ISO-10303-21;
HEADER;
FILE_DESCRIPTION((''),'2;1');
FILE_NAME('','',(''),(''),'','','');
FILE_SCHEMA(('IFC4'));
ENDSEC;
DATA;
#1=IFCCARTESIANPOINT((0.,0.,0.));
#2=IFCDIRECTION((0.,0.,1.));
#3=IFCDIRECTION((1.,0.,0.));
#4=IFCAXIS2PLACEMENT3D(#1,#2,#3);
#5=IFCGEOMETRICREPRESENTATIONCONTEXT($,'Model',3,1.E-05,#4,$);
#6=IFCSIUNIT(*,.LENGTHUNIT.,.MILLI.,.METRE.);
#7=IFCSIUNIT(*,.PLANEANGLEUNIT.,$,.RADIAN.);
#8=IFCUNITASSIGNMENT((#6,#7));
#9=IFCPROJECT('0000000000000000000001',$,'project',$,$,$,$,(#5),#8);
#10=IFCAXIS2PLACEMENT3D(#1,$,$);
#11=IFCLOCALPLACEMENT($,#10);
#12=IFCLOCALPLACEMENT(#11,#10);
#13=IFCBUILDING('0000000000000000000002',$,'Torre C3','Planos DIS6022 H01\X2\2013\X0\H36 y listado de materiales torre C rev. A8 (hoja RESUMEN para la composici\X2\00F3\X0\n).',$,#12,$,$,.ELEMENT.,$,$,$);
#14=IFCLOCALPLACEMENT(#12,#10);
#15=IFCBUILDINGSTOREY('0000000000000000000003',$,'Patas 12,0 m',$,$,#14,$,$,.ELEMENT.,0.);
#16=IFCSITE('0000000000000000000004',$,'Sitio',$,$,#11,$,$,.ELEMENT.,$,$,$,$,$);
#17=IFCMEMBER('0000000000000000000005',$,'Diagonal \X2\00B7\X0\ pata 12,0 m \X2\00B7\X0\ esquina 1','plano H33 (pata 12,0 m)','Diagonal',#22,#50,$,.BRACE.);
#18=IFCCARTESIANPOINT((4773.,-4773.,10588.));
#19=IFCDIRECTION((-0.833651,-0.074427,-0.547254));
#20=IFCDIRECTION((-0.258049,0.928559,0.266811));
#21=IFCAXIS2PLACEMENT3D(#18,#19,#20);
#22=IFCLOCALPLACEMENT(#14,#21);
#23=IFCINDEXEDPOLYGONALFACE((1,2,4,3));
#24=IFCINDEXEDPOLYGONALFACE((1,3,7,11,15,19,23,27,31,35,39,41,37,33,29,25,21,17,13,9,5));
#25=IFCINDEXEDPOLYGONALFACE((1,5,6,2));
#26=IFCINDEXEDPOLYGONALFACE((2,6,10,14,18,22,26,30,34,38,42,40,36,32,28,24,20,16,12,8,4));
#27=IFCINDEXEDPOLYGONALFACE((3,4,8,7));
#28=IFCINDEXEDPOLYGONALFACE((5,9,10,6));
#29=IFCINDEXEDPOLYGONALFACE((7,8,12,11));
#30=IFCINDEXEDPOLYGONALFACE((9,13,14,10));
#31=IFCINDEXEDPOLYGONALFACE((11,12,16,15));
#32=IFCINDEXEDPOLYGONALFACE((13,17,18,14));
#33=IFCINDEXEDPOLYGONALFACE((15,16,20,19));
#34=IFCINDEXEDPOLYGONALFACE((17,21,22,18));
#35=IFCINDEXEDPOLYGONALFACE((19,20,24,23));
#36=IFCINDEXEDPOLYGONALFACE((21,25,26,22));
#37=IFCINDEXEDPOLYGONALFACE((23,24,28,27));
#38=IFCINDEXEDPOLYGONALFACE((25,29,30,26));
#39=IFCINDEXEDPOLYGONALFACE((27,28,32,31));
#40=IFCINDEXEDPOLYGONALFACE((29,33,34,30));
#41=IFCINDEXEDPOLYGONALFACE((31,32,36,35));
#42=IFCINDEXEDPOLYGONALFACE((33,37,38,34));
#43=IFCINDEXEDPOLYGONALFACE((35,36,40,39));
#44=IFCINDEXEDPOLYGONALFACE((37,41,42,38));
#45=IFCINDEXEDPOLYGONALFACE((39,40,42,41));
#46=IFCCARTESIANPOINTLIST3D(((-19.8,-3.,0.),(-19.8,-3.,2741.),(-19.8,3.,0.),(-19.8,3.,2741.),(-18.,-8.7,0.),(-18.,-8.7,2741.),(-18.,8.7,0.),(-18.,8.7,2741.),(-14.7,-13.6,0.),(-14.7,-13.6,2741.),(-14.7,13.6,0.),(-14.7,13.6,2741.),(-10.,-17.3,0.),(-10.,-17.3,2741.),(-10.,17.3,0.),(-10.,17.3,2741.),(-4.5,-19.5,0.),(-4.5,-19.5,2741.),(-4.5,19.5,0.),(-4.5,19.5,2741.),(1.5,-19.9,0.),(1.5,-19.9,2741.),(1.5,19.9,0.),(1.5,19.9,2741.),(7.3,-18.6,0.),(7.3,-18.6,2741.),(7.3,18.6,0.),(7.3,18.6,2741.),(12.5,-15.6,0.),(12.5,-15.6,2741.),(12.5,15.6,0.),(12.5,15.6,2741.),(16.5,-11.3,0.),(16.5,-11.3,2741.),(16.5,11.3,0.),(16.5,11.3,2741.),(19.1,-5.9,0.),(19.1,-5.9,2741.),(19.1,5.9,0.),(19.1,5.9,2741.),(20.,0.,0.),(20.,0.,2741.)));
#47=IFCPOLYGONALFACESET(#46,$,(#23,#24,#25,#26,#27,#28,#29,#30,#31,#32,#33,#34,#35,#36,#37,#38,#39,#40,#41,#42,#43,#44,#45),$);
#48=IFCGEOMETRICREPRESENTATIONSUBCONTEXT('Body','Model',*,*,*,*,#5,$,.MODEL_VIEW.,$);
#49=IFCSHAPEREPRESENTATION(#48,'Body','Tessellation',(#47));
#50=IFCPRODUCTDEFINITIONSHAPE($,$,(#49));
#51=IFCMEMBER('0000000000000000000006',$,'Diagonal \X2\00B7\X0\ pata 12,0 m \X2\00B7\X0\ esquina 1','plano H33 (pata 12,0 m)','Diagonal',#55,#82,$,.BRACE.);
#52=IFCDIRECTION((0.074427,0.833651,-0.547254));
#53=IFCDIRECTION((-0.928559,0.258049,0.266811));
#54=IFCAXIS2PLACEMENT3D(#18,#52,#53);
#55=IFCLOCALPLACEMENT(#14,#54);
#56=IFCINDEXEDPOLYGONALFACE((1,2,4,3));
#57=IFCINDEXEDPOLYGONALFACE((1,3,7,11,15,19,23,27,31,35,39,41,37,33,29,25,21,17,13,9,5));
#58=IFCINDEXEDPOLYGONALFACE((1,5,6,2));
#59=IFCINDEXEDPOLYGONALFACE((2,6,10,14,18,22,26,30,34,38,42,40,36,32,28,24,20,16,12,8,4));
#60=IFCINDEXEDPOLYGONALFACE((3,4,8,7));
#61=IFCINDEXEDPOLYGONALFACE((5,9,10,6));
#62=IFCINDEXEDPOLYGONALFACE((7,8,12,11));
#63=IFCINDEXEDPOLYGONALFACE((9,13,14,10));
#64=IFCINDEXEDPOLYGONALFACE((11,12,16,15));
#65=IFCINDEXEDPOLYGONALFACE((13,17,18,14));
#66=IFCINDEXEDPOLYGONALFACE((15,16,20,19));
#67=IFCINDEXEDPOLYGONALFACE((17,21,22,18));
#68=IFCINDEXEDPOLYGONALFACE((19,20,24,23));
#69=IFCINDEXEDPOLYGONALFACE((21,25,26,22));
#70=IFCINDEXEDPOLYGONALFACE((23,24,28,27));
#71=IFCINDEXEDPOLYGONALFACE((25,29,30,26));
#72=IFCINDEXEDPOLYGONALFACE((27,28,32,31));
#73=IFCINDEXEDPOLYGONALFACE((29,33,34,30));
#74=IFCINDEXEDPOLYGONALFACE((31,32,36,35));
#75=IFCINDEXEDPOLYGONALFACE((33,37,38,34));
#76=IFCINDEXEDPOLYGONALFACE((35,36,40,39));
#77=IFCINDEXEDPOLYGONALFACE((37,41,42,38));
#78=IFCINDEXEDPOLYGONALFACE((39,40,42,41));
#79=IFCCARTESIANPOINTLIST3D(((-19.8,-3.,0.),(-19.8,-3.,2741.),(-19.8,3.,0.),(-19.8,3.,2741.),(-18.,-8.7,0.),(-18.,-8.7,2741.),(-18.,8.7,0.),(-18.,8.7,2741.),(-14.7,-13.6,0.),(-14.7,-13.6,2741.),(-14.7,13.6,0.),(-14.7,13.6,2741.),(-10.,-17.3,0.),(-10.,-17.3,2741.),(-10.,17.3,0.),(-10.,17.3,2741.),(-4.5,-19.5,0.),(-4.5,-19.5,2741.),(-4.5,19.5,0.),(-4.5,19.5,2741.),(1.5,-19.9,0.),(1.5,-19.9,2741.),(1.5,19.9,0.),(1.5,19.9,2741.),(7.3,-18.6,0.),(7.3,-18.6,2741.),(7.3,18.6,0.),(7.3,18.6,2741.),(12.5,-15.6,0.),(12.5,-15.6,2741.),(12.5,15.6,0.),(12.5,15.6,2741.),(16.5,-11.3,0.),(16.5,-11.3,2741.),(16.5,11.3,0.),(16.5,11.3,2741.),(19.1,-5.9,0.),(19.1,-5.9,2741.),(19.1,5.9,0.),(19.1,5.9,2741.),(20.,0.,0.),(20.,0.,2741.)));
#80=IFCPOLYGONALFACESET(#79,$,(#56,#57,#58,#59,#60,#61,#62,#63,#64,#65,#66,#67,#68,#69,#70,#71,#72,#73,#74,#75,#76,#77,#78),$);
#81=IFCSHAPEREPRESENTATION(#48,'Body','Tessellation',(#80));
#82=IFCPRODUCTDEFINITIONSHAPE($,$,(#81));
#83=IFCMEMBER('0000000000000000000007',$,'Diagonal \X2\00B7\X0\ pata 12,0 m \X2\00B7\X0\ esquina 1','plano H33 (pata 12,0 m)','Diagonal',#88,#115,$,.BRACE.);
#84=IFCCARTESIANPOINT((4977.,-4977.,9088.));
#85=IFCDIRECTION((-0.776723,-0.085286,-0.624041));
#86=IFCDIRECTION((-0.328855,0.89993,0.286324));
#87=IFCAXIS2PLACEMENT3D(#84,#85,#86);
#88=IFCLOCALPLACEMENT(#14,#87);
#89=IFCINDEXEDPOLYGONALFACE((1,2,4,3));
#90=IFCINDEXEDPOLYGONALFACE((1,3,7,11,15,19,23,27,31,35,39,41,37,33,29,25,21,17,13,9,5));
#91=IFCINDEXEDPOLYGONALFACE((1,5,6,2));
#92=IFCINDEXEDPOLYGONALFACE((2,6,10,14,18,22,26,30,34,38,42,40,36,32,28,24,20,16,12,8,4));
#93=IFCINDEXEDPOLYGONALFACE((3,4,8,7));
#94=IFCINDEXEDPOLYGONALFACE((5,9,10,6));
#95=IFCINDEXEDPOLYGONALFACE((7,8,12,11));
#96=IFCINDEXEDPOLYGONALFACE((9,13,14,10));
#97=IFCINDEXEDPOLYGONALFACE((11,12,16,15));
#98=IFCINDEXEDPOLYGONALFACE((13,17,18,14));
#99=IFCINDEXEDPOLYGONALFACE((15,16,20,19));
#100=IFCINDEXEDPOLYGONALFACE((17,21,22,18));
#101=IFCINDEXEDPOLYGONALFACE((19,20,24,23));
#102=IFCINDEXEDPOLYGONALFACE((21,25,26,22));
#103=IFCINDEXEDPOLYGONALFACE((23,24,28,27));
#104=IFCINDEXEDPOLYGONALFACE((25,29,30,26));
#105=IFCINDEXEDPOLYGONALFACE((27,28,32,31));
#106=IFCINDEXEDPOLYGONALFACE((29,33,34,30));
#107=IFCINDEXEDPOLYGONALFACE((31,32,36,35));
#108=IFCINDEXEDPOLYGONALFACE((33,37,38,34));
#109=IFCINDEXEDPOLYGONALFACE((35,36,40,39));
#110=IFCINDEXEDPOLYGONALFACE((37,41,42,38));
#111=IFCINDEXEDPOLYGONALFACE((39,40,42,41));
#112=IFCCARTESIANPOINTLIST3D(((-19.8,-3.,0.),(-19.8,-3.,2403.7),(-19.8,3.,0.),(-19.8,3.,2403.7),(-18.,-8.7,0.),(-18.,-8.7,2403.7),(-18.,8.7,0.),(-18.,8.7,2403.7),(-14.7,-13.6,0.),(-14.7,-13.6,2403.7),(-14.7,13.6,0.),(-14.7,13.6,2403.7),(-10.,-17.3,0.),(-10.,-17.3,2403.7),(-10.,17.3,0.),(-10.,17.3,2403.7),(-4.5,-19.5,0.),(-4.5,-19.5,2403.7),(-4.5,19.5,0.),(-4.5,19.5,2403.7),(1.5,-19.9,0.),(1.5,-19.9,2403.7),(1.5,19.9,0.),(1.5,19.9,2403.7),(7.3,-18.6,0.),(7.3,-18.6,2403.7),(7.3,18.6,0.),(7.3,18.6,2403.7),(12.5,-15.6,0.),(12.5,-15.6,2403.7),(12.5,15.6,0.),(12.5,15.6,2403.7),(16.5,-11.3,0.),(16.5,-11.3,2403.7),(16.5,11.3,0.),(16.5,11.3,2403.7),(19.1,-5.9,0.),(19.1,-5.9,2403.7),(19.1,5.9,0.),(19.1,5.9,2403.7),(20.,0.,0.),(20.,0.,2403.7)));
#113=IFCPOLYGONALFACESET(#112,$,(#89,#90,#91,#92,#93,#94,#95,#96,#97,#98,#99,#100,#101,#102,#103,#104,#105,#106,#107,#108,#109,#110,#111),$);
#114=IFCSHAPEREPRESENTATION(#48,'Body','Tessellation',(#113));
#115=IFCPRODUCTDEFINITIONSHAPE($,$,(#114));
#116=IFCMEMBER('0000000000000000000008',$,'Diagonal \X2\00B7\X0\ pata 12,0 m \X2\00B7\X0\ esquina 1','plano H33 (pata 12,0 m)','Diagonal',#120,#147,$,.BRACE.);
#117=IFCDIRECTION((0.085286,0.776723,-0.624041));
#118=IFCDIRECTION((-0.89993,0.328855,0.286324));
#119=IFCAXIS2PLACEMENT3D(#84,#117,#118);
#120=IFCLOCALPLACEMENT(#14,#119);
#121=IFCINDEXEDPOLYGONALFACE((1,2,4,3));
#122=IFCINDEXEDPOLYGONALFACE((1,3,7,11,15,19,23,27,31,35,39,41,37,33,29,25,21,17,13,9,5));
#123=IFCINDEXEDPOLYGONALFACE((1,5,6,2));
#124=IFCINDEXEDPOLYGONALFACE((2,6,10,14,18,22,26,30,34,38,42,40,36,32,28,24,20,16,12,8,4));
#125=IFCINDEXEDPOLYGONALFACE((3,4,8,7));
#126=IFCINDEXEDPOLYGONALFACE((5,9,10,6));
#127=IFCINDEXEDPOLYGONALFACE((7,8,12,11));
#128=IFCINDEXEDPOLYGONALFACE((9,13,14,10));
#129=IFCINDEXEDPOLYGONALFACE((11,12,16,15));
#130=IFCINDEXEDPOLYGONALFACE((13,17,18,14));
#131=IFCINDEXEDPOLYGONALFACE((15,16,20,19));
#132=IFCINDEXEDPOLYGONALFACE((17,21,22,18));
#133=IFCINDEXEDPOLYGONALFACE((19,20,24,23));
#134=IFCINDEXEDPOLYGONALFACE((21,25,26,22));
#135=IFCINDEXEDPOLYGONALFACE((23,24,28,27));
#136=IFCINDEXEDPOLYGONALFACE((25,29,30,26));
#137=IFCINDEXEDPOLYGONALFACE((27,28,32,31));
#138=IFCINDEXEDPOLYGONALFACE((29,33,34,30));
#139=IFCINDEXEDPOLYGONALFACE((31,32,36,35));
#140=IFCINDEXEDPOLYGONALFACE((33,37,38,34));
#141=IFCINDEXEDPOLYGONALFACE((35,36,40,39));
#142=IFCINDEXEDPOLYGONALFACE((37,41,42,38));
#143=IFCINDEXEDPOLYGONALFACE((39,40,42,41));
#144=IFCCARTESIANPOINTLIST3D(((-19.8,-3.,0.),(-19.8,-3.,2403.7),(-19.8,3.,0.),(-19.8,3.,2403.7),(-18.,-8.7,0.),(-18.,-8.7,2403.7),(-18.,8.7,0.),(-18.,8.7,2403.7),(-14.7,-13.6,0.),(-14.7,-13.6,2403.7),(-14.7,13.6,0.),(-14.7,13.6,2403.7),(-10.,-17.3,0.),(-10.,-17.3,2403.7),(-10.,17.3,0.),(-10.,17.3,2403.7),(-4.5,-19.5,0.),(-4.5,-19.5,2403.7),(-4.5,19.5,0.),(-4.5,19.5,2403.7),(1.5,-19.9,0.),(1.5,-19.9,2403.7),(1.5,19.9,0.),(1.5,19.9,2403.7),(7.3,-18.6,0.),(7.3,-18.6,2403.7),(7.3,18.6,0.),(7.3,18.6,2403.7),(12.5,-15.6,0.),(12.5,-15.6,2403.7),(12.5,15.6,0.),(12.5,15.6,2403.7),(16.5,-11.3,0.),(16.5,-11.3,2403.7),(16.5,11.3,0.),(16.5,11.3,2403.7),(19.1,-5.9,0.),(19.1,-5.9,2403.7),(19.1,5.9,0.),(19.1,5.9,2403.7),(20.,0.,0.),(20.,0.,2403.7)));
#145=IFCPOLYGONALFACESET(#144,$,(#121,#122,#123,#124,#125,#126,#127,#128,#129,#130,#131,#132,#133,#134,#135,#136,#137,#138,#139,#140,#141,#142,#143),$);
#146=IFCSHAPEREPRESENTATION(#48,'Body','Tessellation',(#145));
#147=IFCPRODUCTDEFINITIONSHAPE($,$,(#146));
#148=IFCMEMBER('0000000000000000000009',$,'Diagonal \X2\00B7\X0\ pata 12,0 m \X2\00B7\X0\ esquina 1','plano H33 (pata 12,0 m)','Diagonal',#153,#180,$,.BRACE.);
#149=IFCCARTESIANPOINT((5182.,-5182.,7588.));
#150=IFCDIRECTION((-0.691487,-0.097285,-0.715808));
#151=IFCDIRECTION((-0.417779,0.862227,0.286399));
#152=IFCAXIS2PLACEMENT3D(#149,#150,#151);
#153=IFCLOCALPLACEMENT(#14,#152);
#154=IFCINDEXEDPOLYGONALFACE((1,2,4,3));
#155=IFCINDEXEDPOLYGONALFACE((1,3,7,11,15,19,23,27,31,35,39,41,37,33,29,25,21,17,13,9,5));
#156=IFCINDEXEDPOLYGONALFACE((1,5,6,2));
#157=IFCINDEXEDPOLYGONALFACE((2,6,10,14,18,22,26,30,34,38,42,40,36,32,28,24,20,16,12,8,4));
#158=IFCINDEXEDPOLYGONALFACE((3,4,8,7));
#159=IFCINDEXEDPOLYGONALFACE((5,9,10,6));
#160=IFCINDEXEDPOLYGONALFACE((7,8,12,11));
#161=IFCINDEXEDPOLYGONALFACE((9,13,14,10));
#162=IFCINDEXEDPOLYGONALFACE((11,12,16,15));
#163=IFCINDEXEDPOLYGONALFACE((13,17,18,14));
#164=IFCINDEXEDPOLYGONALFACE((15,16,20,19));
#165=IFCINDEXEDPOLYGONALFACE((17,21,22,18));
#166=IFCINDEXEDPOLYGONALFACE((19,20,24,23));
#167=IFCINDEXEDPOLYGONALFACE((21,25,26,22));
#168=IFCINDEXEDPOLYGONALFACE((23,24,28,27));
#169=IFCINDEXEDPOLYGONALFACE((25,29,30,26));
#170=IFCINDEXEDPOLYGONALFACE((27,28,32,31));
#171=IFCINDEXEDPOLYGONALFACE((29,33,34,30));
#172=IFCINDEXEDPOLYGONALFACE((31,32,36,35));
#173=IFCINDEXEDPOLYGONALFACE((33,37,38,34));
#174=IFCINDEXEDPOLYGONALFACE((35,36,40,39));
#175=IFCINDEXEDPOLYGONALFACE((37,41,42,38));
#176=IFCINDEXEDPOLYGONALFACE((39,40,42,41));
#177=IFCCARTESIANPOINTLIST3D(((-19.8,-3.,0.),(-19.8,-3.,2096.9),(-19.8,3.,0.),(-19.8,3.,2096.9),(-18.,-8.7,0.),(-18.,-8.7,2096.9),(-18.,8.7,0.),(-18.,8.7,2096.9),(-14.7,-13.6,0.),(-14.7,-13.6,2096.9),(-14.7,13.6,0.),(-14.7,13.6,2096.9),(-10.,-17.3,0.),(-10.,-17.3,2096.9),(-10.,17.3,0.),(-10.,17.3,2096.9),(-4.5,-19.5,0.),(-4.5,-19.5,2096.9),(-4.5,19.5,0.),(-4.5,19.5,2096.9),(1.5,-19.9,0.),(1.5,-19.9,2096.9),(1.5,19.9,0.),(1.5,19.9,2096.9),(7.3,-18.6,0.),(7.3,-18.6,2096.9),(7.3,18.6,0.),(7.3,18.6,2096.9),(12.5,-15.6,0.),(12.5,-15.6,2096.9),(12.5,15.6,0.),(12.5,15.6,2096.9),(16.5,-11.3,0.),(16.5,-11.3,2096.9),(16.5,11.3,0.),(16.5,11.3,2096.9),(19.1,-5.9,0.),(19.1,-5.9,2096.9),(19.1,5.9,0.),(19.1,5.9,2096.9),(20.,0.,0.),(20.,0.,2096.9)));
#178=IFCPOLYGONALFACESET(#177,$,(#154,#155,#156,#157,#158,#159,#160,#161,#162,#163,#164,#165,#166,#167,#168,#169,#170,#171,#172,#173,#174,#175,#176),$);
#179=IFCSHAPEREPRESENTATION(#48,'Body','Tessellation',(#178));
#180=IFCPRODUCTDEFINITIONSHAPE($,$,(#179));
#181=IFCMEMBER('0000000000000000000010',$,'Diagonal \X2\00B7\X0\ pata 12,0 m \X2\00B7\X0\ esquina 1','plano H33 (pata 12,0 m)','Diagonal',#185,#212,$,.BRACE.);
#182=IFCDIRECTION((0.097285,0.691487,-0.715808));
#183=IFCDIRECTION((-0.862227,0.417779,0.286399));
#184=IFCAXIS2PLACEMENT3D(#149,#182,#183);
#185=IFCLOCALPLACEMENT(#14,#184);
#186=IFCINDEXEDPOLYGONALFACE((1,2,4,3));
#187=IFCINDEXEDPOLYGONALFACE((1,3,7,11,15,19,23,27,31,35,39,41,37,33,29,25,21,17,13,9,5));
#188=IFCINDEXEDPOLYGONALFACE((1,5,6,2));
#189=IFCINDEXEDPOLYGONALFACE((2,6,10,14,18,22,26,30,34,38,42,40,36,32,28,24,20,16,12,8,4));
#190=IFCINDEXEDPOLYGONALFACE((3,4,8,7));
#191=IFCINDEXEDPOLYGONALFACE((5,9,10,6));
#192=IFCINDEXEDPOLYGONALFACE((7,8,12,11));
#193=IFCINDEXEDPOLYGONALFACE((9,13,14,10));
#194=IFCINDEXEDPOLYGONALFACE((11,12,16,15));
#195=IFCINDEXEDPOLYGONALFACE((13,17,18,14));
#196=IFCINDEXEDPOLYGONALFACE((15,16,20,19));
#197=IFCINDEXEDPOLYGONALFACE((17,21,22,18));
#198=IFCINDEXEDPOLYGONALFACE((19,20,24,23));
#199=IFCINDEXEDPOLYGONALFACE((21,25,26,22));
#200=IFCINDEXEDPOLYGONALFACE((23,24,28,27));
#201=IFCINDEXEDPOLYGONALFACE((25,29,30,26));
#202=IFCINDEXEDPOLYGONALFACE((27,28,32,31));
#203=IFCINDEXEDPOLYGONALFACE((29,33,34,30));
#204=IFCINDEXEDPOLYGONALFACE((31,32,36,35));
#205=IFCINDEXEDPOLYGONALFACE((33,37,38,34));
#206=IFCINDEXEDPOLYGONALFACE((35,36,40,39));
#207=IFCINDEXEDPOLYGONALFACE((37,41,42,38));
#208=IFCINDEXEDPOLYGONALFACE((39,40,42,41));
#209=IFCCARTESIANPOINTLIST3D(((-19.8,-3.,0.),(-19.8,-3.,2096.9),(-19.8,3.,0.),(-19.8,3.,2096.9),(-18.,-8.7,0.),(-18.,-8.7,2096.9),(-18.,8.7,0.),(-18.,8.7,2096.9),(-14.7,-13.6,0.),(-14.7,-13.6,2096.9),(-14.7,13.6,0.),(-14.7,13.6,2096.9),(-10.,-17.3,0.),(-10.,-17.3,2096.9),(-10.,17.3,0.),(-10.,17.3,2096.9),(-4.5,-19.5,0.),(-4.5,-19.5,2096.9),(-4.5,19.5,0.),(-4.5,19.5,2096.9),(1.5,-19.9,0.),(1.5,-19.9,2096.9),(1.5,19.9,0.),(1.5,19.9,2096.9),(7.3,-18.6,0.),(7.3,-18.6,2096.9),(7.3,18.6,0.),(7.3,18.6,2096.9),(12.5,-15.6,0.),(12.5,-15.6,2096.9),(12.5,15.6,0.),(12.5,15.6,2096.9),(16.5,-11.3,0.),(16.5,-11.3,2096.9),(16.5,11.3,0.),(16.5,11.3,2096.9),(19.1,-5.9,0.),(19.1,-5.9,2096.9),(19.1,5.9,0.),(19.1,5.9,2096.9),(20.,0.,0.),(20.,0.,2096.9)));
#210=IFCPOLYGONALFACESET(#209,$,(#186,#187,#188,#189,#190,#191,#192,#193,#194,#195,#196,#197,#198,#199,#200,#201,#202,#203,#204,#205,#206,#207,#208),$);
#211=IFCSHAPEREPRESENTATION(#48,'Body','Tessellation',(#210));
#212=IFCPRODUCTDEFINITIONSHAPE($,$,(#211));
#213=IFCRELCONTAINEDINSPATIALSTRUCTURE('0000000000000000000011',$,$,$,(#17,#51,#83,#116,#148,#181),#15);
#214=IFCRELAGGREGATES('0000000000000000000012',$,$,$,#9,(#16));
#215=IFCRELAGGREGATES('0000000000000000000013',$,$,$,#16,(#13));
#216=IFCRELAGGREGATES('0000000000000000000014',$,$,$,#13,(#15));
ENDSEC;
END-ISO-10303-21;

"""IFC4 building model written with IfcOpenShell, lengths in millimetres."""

from ifc_helpers import new_model, si_unit, frame, origin, origin_with_axes, place, context, subcontext, project, spatial, circle, extrude, element, save


model = new_model("IFC4")

# Units and contexts
model_context = context("Model", 3, precision=1e-05, world=origin_with_axes())
body_context = subcontext(model_context, "Body", "Model", "MODEL_VIEW")
ifc_project = project(units=[si_unit("LENGTHUNIT", "METRE", prefix="MILLI"), si_unit("PLANEANGLEUNIT", "RADIAN")], contexts=[model_context])

# Site, building, storey
site_placement = place(None, origin())
site = spatial("IfcSite", under=ifc_project, at=site_placement, Name="Sitio", CompositionType="ELEMENT")
building_placement = place(site_placement, origin())
building = spatial("IfcBuilding", under=site, at=building_placement, Name="Torre C3", Description="Planos DIS6022 H01–H36 y listado de materiales torre C rev. A8 (hoja RESUMEN para la composición).", CompositionType="ELEMENT")
storey_placement = place(building_placement, origin())
storey = spatial("IfcBuildingStorey", under=building, at=storey_placement, Name="Patas 12,0 m", CompositionType="ELEMENT", Elevation=0.0)

# Members
for number, where, z_axis, x_axis, name in (
    (1, (4773.0, -4773.0, 10588.0), (-0.833651, -0.074427, -0.547254), (-0.258049, 0.928559, 0.266811), "Diagonal · pata 12,0 m · esquina 1"),
    (2, (4773.0, -4773.0, 10588.0), (0.074427, 0.833651, -0.547254), (-0.928559, 0.258049, 0.266811), "Diagonal · pata 12,0 m · esquina 1"),
):
    element("IfcMember", number, at=place(storey_placement, frame(where, z_axis=z_axis, x_axis=x_axis)), inside=storey, Name=name, Description="plano H33 (pata 12,0 m)", ObjectType="Diagonal", PredefinedType="BRACE", context=body_context, shape_type="SweptSolid", body=[
        extrude(circle(Radius=20.0), None, (0.0, 0.0, 1.0), 2741.0),
    ])
for number, where, z_axis, x_axis, name in (
    (3, (4977.0, -4977.0, 9088.0), (-0.776723, -0.085286, -0.624041), (-0.328855, 0.89993, 0.286324), "Diagonal · pata 12,0 m · esquina 1"),
    (4, (4977.0, -4977.0, 9088.0), (0.085286, 0.776723, -0.624041), (-0.89993, 0.328855, 0.286324), "Diagonal · pata 12,0 m · esquina 1"),
):
    element("IfcMember", number, at=place(storey_placement, frame(where, z_axis=z_axis, x_axis=x_axis)), inside=storey, Name=name, Description="plano H33 (pata 12,0 m)", ObjectType="Diagonal", PredefinedType="BRACE", context=body_context, shape_type="SweptSolid", body=[
        extrude(circle(Radius=20.0), None, (0.0, 0.0, 1.0), 2403.7),
    ])
for number, where, z_axis, x_axis, name in (
    (5, (5182.0, -5182.0, 7588.0), (-0.691487, -0.097285, -0.715808), (-0.417779, 0.862227, 0.286399), "Diagonal · pata 12,0 m · esquina 1"),
    (6, (5182.0, -5182.0, 7588.0), (0.097285, 0.691487, -0.715808), (-0.862227, 0.417779, 0.286399), "Diagonal · pata 12,0 m · esquina 1"),
):
    element("IfcMember", number, at=place(storey_placement, frame(where, z_axis=z_axis, x_axis=x_axis)), inside=storey, Name=name, Description="plano H33 (pata 12,0 m)", ObjectType="Diagonal", PredefinedType="BRACE", context=body_context, shape_type="SweptSolid", body=[
        extrude(circle(Radius=20.0), None, (0.0, 0.0, 1.0), 2096.9),
    ])

save(model, "model.ifc")
